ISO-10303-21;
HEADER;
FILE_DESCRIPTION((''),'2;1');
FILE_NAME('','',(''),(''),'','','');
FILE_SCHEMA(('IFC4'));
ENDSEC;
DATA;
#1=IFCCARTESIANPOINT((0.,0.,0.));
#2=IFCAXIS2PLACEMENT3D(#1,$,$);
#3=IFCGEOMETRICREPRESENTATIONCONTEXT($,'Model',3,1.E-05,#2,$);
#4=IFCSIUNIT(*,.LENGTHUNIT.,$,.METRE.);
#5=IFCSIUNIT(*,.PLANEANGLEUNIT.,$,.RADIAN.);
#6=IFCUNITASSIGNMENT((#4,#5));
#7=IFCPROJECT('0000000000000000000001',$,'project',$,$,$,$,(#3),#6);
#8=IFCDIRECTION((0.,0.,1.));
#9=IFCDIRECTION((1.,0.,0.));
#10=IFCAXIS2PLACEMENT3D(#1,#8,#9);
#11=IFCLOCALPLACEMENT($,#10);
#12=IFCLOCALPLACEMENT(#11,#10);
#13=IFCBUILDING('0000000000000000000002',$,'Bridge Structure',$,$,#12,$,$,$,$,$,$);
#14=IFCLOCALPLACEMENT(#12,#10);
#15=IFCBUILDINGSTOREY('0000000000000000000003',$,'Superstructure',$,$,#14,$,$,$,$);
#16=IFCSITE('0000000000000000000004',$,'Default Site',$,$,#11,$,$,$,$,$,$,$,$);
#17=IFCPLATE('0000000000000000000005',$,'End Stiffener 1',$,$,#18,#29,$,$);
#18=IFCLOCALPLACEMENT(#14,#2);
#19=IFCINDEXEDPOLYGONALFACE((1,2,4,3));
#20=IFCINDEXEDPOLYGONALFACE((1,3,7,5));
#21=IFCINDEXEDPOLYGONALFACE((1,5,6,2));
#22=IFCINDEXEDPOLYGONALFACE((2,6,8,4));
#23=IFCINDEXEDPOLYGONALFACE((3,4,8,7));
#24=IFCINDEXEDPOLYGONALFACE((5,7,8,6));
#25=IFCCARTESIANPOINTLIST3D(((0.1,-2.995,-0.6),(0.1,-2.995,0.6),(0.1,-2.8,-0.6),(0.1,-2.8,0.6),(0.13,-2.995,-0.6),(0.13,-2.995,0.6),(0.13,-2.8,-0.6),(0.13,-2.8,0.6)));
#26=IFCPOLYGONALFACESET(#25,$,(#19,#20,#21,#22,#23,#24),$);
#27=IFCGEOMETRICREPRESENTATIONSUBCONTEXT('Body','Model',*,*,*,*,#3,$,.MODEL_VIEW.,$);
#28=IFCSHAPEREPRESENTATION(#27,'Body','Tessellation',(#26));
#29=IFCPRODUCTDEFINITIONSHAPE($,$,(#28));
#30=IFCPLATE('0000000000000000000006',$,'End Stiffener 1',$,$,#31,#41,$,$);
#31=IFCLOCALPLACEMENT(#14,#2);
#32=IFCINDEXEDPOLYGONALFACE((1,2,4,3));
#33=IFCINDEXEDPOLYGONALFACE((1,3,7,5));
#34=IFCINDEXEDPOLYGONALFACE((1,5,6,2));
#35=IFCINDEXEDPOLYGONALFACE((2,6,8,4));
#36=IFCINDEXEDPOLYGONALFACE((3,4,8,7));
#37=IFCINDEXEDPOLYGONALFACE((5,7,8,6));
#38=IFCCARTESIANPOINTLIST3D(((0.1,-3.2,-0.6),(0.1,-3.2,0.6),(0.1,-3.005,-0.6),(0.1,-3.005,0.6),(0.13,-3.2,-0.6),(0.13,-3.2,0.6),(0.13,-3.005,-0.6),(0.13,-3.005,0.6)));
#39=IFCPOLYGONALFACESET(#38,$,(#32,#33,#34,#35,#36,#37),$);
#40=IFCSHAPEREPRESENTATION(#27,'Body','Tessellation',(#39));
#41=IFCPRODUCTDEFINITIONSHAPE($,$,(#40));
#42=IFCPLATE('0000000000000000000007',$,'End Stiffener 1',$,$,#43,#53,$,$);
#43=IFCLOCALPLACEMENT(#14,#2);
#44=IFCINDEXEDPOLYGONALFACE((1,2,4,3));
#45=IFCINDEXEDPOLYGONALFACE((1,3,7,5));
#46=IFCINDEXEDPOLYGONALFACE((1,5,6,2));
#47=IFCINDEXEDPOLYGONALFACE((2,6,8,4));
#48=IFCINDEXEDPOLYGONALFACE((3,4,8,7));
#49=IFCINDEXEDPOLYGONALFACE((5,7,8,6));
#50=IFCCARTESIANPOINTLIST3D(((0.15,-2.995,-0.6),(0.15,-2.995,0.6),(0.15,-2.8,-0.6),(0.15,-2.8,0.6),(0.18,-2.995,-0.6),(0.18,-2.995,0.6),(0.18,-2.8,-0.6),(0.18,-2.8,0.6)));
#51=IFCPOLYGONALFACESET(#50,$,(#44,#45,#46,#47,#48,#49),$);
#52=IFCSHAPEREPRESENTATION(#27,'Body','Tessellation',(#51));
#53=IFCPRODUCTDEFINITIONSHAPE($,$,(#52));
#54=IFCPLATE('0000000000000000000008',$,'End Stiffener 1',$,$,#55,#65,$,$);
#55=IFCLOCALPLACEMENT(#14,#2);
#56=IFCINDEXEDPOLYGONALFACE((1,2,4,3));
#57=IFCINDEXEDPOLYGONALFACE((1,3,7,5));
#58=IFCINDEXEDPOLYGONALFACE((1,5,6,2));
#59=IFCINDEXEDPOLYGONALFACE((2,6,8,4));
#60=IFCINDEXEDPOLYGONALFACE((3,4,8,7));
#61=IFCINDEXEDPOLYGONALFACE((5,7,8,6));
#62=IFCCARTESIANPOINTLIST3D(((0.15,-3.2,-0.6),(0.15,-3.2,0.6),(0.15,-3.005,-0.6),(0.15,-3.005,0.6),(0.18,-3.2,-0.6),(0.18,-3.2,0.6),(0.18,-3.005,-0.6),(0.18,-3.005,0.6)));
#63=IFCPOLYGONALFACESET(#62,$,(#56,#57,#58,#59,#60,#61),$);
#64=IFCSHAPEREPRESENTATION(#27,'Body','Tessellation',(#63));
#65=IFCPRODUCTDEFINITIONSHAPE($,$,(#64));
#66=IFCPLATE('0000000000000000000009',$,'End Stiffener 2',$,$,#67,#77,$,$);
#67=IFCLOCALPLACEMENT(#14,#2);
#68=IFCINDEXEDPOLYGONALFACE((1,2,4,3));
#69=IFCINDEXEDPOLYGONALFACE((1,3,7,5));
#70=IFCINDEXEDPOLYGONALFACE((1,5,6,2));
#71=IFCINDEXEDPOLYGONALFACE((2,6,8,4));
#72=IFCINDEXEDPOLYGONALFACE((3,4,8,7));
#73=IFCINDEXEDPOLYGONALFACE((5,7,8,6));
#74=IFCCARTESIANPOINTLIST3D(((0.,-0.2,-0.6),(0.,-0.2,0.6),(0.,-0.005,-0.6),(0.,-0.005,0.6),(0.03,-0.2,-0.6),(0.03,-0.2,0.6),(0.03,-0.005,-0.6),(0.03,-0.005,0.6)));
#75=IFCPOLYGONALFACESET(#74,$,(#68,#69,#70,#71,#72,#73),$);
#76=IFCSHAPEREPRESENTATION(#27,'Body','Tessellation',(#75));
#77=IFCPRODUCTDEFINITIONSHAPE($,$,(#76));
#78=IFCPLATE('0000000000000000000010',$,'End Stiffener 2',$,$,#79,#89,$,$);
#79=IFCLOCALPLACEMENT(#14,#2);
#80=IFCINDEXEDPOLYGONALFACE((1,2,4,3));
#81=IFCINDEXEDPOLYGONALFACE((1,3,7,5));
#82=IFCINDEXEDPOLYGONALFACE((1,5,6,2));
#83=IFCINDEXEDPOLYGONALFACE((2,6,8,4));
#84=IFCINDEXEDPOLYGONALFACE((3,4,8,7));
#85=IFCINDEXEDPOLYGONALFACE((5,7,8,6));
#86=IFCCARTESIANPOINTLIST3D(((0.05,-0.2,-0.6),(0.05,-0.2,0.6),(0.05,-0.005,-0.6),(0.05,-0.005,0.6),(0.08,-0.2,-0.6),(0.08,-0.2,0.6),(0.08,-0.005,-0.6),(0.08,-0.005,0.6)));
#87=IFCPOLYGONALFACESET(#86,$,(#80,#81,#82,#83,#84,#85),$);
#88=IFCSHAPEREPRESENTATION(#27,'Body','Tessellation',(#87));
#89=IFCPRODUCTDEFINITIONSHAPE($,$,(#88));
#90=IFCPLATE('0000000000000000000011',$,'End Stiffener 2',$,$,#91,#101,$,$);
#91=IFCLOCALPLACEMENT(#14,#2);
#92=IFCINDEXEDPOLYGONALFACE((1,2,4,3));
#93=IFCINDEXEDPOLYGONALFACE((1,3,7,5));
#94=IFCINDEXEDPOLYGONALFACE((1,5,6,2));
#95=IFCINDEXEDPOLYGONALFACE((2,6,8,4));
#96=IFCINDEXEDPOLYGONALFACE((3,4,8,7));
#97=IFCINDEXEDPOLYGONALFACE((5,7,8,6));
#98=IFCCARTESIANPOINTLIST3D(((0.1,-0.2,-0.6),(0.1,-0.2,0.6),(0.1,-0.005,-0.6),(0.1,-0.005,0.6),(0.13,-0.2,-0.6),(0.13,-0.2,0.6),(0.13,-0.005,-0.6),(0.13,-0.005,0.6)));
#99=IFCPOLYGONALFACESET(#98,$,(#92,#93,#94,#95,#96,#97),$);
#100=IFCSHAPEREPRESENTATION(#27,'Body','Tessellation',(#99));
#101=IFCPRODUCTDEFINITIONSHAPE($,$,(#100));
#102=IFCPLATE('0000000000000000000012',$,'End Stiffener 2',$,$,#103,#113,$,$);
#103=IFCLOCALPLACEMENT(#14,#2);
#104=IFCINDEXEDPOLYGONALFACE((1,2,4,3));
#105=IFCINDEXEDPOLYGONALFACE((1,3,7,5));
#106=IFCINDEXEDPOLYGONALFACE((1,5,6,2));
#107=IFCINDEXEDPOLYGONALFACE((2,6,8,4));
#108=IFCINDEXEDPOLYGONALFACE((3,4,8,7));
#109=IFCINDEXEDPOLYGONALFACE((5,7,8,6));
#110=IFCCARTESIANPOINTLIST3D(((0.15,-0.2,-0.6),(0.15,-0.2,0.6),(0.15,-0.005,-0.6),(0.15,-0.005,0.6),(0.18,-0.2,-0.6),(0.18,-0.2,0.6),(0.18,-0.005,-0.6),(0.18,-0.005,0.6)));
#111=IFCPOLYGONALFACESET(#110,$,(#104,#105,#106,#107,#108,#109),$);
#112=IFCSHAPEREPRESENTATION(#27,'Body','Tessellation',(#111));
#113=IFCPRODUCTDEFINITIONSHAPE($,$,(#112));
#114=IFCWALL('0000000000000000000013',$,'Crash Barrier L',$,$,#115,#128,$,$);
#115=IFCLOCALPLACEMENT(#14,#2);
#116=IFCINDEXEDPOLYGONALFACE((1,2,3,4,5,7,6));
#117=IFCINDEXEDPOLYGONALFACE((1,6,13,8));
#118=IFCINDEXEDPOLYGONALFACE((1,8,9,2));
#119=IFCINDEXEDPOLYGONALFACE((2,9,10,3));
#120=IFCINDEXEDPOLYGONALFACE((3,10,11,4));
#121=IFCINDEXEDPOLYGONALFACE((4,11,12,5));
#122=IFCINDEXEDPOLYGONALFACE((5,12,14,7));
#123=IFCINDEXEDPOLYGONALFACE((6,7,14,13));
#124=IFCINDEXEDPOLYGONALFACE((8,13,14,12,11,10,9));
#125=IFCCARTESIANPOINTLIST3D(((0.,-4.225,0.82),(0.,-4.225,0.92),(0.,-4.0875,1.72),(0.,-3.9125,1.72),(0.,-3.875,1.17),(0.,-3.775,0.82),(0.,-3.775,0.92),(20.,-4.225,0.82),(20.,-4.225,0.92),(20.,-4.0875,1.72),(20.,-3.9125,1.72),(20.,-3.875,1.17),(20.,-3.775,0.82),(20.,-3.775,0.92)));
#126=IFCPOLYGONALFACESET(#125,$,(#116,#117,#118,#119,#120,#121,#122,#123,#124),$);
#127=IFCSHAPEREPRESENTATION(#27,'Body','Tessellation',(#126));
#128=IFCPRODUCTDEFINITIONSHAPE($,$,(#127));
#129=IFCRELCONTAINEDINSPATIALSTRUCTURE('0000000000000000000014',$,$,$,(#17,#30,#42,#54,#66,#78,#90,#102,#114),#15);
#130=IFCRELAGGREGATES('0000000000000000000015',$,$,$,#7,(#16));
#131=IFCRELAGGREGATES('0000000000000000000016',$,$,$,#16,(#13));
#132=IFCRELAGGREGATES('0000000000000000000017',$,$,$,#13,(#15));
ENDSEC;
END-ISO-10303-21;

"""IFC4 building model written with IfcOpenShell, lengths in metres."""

from ifc_helpers import new_model, si_unit, frame, origin, origin_with_axes, origin_2d_with_axis, place, context, subcontext, project, spatial, polyline, rectangle, outline, extrude, element, save


model = new_model("IFC4")

# Units and contexts
model_context = context("Model", 3, precision=1e-05, world=origin())
body_context = subcontext(model_context, "Body", "Model", "MODEL_VIEW")
ifc_project = project(units=[si_unit("LENGTHUNIT", "METRE"), si_unit("PLANEANGLEUNIT", "RADIAN")], contexts=[model_context])

# Site, building, storey
site_placement = place(None, origin_with_axes())
site = spatial("IfcSite", under=ifc_project, at=site_placement, Name="Default Site")
building_placement = place(site_placement, origin_with_axes())
building = spatial("IfcBuilding", under=site, at=building_placement, Name="Bridge Structure")
storey_placement = place(building_placement, origin_with_axes())
storey = spatial("IfcBuildingStorey", under=building, at=storey_placement, Name="Superstructure")

# Plates
for number, where, z_axis, x_axis, name in (
    (1, (0.115, -2.8975, -0.6), (0.0, 0.0, 1.0), (1.0, 0.0, 0.0), "End Stiffener 1"),
    (2, (0.115, -3.1025, -0.6), (0.0, 0.0, 1.0), (1.0, 0.0, 0.0), "End Stiffener 1"),
    (3, (0.165, -2.8975, -0.6), (0.0, 0.0, 1.0), (1.0, 0.0, 0.0), "End Stiffener 1"),
    (4, (0.165, -3.1025, -0.6), (0.0, 0.0, 1.0), (1.0, 0.0, 0.0), "End Stiffener 1"),
    (5, (0.015, -0.1025, -0.6), (0.0, 0.0, 1.0), (1.0, 0.0, 0.0), "End Stiffener 2"),
    (6, (0.065, -0.1025, -0.6), (0.0, 0.0, 1.0), (1.0, 0.0, 0.0), "End Stiffener 2"),
    (7, (0.115, -0.1025, -0.6), (0.0, 0.0, 1.0), (1.0, 0.0, 0.0), "End Stiffener 2"),
    (8, (0.165, -0.1025, -0.6), (0.0, 0.0, 1.0), (1.0, 0.0, 0.0), "End Stiffener 2"),
):
    element("IfcPlate", number, at=place(storey_placement, frame(where, z_axis=z_axis, x_axis=x_axis)), inside=storey, Name=name, context=body_context, shape_type="SweptSolid", body=[
        extrude(rectangle(XDim=0.03, YDim=0.195, at=origin_2d_with_axis()), origin_with_axes(), (0.0, 0.0, 1.0), 1.2),
    ])

# Wall
wall_placement = place(storey_placement, frame((0.0, -4.225, 0.82), z_axis=(1.0, 0.0, 0.0), x_axis=(0.0, 1.0, 0.0)))
element("IfcWall", 9, at=wall_placement, inside=storey, Name="Crash Barrier L", context=body_context, shape_type="SweptSolid", body=[
    extrude(outline(polyline([(0.0, 0.0), (0.45, 0.0), (0.45, 0.1), (0.35, 0.35), (0.3125, 0.9), (0.1375, 0.9), (0.0, 0.1), (0.0, 0.0)])), origin_with_axes(), (0.0, 0.0, 1.0), 20.0),
])

save(model, "model.ifc")
